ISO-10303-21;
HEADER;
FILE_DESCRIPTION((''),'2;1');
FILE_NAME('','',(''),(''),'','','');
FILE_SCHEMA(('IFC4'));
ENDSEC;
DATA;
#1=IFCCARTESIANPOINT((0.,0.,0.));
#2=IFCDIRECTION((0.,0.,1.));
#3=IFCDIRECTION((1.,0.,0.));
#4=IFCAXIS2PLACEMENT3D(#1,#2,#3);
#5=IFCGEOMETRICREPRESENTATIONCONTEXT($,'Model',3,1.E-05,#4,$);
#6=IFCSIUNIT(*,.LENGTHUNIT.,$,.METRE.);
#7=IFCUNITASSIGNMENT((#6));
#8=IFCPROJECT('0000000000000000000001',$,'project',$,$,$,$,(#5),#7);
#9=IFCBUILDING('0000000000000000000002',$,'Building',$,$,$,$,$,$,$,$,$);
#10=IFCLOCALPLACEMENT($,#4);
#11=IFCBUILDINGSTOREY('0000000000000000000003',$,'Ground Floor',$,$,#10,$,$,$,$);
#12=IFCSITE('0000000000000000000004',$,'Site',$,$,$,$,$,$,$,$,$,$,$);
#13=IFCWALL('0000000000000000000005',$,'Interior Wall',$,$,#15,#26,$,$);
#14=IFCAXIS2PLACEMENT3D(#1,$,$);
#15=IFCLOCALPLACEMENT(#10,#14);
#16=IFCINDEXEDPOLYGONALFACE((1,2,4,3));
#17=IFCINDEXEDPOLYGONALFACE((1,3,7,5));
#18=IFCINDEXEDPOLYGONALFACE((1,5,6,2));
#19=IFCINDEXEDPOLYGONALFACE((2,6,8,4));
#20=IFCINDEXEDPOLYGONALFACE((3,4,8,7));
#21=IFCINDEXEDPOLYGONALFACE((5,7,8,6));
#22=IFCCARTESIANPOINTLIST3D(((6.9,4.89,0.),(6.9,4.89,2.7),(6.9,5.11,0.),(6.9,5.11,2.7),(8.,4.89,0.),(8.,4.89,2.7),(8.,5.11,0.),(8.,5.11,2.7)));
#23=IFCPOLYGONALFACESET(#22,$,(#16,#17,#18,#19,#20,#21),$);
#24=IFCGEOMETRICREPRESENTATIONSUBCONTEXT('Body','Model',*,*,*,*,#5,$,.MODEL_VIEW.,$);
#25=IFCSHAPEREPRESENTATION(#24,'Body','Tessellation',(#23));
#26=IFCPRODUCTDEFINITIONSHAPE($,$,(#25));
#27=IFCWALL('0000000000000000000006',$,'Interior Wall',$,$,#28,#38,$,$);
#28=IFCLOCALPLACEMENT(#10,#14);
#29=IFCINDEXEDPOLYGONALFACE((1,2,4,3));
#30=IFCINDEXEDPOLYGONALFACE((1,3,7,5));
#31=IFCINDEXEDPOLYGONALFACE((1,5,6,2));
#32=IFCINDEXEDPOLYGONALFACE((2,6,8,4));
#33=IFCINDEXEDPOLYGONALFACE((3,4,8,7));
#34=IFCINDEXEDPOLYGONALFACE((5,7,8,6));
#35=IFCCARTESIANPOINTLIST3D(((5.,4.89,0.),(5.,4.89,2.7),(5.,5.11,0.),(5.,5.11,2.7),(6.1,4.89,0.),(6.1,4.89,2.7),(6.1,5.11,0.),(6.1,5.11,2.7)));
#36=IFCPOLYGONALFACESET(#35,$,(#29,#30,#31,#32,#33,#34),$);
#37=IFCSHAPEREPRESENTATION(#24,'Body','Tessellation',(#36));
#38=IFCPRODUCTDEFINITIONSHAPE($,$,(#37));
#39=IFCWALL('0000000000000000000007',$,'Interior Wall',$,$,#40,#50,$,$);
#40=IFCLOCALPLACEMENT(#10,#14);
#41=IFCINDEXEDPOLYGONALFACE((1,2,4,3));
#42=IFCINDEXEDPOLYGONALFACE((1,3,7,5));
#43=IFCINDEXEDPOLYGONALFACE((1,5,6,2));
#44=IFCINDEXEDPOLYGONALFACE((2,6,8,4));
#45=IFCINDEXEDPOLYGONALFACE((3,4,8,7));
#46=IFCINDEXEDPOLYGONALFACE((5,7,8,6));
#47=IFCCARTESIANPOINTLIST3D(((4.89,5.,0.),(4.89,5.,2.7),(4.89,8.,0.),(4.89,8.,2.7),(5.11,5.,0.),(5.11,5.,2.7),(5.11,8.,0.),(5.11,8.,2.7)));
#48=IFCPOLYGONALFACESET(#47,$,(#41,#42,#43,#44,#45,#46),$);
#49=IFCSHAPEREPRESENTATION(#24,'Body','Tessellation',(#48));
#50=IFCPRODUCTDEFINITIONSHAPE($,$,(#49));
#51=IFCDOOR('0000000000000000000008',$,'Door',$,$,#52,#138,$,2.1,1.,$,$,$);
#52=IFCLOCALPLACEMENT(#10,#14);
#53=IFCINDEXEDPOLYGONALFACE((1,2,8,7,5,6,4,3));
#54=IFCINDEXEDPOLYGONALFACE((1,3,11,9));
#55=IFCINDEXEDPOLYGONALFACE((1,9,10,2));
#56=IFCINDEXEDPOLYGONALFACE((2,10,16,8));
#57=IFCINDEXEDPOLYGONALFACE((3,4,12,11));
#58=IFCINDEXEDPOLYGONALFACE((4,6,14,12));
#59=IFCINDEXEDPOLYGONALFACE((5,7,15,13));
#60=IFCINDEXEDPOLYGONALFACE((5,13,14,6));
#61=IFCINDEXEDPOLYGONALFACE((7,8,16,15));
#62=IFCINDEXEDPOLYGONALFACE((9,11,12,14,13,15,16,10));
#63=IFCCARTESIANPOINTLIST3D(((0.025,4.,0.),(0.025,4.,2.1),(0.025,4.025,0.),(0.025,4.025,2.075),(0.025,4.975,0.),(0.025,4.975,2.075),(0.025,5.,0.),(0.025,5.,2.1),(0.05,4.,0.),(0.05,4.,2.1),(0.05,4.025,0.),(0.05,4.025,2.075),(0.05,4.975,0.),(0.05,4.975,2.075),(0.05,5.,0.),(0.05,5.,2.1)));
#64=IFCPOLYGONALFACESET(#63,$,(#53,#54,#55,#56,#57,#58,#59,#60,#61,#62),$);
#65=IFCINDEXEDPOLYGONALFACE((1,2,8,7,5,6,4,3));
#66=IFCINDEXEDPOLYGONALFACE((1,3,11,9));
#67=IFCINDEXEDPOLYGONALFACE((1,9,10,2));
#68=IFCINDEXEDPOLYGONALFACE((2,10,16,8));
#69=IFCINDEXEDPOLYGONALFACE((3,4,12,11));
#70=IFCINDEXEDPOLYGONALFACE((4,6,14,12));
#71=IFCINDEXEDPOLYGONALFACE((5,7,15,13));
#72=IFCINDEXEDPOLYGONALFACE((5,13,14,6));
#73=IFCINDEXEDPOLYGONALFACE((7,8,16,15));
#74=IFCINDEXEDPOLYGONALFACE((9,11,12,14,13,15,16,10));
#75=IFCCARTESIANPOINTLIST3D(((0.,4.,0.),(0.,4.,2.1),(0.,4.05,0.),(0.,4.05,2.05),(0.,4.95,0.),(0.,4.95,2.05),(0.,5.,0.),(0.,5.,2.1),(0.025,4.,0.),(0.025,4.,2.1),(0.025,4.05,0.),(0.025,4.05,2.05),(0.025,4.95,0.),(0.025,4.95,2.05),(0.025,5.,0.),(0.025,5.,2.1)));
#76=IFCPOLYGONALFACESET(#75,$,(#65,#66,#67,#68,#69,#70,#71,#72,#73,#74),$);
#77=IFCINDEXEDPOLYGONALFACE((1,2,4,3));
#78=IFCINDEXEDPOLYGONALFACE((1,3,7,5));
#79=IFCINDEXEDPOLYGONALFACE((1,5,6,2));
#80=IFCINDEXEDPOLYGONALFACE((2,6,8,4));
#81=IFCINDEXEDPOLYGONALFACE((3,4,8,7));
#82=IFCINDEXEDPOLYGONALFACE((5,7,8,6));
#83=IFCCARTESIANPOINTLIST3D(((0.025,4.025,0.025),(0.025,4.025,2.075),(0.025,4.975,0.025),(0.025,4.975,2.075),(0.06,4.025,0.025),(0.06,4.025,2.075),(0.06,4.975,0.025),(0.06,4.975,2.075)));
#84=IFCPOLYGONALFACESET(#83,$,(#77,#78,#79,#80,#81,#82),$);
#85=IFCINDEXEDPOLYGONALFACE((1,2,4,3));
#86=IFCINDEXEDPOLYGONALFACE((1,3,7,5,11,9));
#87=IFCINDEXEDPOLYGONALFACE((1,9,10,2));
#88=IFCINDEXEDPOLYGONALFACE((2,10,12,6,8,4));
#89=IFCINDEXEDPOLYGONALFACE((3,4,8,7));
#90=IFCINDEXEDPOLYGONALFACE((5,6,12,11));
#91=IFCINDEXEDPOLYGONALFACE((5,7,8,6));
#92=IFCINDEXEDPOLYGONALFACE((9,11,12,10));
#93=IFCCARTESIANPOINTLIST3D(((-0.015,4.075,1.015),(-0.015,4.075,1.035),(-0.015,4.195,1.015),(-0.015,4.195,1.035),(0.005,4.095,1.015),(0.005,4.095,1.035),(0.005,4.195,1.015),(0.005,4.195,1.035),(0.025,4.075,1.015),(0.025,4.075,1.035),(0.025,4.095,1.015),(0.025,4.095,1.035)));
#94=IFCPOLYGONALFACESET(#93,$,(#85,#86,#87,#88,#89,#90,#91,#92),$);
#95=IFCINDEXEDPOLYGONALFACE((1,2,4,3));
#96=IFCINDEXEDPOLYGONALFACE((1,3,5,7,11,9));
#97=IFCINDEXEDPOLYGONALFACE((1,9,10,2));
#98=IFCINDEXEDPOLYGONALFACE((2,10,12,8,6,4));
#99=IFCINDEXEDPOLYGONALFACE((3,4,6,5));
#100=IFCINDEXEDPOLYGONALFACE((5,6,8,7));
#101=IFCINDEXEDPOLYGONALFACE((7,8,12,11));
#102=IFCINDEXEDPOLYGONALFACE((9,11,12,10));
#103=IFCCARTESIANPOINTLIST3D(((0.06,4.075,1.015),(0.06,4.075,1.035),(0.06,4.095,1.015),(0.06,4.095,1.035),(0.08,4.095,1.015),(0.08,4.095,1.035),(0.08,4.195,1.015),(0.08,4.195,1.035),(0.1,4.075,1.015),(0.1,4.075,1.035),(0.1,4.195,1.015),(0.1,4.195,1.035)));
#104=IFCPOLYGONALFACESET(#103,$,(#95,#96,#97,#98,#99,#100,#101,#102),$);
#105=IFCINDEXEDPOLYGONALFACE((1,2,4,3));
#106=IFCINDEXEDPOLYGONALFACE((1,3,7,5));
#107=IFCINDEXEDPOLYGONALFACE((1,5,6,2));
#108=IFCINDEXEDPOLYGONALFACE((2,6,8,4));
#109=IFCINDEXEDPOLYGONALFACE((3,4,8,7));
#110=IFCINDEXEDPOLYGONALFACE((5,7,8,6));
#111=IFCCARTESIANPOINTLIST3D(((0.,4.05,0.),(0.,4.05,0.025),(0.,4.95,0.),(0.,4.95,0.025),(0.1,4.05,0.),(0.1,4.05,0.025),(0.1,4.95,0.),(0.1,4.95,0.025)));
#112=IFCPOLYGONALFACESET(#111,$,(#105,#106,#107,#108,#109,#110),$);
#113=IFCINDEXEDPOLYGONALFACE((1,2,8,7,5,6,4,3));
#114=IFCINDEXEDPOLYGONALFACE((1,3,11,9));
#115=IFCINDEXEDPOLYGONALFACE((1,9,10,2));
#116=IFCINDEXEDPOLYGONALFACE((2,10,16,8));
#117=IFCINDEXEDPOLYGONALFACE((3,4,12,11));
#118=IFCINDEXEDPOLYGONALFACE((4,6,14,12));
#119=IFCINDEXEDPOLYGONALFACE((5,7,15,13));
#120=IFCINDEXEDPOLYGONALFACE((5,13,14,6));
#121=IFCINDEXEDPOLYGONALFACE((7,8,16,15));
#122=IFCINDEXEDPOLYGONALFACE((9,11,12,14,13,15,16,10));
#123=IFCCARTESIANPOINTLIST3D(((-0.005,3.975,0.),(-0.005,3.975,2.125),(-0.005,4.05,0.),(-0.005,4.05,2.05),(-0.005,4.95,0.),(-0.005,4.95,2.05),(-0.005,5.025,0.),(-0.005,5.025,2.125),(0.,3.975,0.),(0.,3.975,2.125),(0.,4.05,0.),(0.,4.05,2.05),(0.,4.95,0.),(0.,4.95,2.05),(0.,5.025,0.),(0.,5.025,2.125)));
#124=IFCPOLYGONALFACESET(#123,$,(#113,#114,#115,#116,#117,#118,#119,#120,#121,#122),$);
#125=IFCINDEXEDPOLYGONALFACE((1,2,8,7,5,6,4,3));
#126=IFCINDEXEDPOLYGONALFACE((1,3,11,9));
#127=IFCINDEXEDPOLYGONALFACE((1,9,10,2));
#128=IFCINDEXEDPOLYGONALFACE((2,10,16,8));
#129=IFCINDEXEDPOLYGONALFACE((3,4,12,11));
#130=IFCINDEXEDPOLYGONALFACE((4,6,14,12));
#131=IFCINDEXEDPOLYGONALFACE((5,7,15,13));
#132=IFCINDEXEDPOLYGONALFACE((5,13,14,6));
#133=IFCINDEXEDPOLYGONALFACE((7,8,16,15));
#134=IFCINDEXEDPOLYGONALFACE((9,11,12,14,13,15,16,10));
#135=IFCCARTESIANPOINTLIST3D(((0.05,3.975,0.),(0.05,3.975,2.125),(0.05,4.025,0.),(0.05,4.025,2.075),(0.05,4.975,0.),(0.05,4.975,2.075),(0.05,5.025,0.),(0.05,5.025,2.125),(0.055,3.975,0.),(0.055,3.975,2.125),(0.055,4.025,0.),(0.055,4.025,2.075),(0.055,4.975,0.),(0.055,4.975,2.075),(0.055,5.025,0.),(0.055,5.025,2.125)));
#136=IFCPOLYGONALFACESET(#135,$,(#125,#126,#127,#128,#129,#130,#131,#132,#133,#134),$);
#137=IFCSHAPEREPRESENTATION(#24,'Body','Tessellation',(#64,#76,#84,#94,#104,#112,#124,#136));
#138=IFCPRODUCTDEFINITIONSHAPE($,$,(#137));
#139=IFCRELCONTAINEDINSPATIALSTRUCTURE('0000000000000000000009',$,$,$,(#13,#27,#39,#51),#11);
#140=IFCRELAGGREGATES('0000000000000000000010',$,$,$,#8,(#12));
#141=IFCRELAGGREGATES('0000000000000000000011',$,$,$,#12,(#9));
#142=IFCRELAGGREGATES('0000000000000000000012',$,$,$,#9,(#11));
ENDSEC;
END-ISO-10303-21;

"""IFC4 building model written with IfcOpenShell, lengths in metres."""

from ifc_helpers import new_model, si_unit, frame, origin_with_axes, place, context, subcontext, project, spatial, line, indexed_curve, outline, extrude, element, save


model = new_model("IFC4")

# Units and contexts
model_context = context("Model", 3, precision=1e-05, world=origin_with_axes())
body_context = subcontext(model_context, "Body", "Model", "MODEL_VIEW")
ifc_project = project(units=[si_unit("LENGTHUNIT", "METRE")], contexts=[model_context])

# Site, building, storey
site = spatial("IfcSite", under=ifc_project, Name="Site")
building = spatial("IfcBuilding", under=site, Name="Building")
storey_placement = place(None, origin_with_axes())
storey = spatial("IfcBuildingStorey", under=building, at=storey_placement, Name="Ground Floor")

# Walls
for number, where, z_axis, x_axis, name in (
    (1, (8.0, 5.0, 0.0), (0.0, 0.0, 1.0), (-1.0, 0.0, 0.0), "Interior Wall"),
    (2, (6.1, 5.0, 0.0), (0.0, 0.0, 1.0), (-1.0, 0.0, 0.0), "Interior Wall"),
):
    element("IfcWall", number, at=place(storey_placement, frame(where, z_axis=z_axis, x_axis=x_axis)), inside=storey, Name=name, context=body_context, shape_type="SweptSolid", body=[
        extrude(outline(indexed_curve([(0.0, 0.0), (0.0, 0.22), (1.1, 0.22), (1.1, 0.0), (0.0, 0.0)], self_intersect=False)), frame((0.0, -0.11, 0.0), z_axis=(0.0, 0.0, 1.0), x_axis=(1.0, 0.0, 0.0)), (0.0, 0.0, 1.0), 2.7),
    ])
wall_1_placement = place(storey_placement, frame((5.0, 5.0, 0.0), z_axis=(0.0, 0.0, 1.0), x_axis=(0.0, 1.0, 0.0)))
element("IfcWall", 3, at=wall_1_placement, inside=storey, Name="Interior Wall", context=body_context, shape_type="SweptSolid", body=[
    extrude(outline(indexed_curve([(0.0, 0.0), (0.0, 0.22), (3.0, 0.22), (3.0, 0.0), (0.0, 0.0)], self_intersect=False)), frame((0.0, -0.11, 0.0), z_axis=(0.0, 0.0, 1.0), x_axis=(1.0, 0.0, 0.0)), (0.0, 0.0, 1.0), 2.7),
])

# Door
door_1_placement = place(storey_placement, frame((0.0, 5.0, 0.0), z_axis=(0.0, 0.0, 1.0), x_axis=(0.0, -1.0, 0.0)))
element("IfcDoor", 4, at=door_1_placement, inside=storey, Name="Door", OverallHeight=2.1, OverallWidth=1.0, context=body_context, shape_type="SweptSolid", body=[
    extrude(outline(indexed_curve([(0.0, 0.0), (0.0, 2.1), (1.0, 2.1), (1.0, 0.0), (0.975, 0.0), (0.975, 2.075), (0.025, 2.075), (0.025, 0.0)], segments=[line(1, 2, 3, 4, 5, 6, 7, 8, 1)])), frame((0.0, 0.025, 0.0), z_axis=(0.0, -1.0, 0.0), x_axis=(1.0, 0.0, 0.0)), (0.0, 0.0, -1.0), 0.025),
    extrude(outline(indexed_curve([(0.0, 0.0), (0.0, 2.1), (1.0, 2.1), (1.0, 0.0), (0.95, 0.0), (0.95, 2.05), (0.05, 2.05), (0.05, 0.0)], segments=[line(1, 2, 3, 4, 5, 6, 7, 8, 1)])), frame((0.0, 0.0, 0.0), z_axis=(0.0, -1.0, 0.0), x_axis=(1.0, 0.0, 0.0)), (0.0, 0.0, -1.0), 0.025),
    extrude(outline(indexed_curve([(0.0, 0.0), (0.95, 0.0), (0.95, 0.035), (0.0, 0.035)], segments=[line(1, 2, 3, 4, 1)])), frame((0.025, 0.025, 0.025), z_axis=(0.0, 0.0, 1.0), x_axis=(1.0, 0.0, 0.0)), (0.0, 0.0, 1.0), 2.05),
    extrude(outline(indexed_curve([(0.0, 0.0), (0.0, -0.04), (-0.12, -0.04), (-0.12, -0.02), (-0.02, -0.02), (-0.02, 0.0)], segments=[line(1, 2, 3, 4, 5, 6, 1)])), frame((0.925, 0.025, 1.015), z_axis=(0.0, 0.0, 1.0), x_axis=(1.0, 0.0, 0.0)), (0.0, 0.0, 1.0), 0.02),
    extrude(outline(indexed_curve([(0.0, 0.0), (0.0, 0.04), (-0.12, 0.04), (-0.12, 0.02), (-0.02, 0.02), (-0.02, 0.0)], segments=[line(1, 2, 3, 4, 5, 6, 1)])), frame((0.925, 0.06, 1.015), z_axis=(0.0, 0.0, 1.0), x_axis=(1.0, 0.0, 0.0)), (0.0, 0.0, 1.0), 0.02),
    extrude(outline(indexed_curve([(0.0, 0.0), (0.9, 0.0), (0.9, 0.1), (0.0, 0.1)], segments=[line(1, 2, 3, 4, 1)])), frame((0.05, 0.0, 0.0), z_axis=(0.0, 0.0, 1.0), x_axis=(1.0, 0.0, 0.0)), (0.0, 0.0, 1.0), 0.025),
    extrude(outline(indexed_curve([(0.0, 0.0), (0.0, 2.125), (1.05, 2.125), (1.05, 0.0), (0.975, 0.0), (0.975, 2.05), (0.075, 2.05), (0.075, 0.0)], segments=[line(1, 2, 3, 4, 5, 6, 7, 8, 1)])), frame((-0.025, -0.005, 0.0), z_axis=(0.0, -1.0, 0.0), x_axis=(1.0, 0.0, 0.0)), (0.0, 0.0, -1.0), 0.005),
    extrude(outline(indexed_curve([(0.0, 0.0), (0.0, 2.125), (1.05, 2.125), (1.05, 0.0), (1.0, 0.0), (1.0, 2.075), (0.05, 2.075), (0.05, 0.0)], segments=[line(1, 2, 3, 4, 5, 6, 7, 8, 1)])), frame((-0.025, 0.05, 0.0), z_axis=(0.0, -1.0, 0.0), x_axis=(1.0, 0.0, 0.0)), (0.0, 0.0, -1.0), 0.005),
])

save(model, "model.ifc")
